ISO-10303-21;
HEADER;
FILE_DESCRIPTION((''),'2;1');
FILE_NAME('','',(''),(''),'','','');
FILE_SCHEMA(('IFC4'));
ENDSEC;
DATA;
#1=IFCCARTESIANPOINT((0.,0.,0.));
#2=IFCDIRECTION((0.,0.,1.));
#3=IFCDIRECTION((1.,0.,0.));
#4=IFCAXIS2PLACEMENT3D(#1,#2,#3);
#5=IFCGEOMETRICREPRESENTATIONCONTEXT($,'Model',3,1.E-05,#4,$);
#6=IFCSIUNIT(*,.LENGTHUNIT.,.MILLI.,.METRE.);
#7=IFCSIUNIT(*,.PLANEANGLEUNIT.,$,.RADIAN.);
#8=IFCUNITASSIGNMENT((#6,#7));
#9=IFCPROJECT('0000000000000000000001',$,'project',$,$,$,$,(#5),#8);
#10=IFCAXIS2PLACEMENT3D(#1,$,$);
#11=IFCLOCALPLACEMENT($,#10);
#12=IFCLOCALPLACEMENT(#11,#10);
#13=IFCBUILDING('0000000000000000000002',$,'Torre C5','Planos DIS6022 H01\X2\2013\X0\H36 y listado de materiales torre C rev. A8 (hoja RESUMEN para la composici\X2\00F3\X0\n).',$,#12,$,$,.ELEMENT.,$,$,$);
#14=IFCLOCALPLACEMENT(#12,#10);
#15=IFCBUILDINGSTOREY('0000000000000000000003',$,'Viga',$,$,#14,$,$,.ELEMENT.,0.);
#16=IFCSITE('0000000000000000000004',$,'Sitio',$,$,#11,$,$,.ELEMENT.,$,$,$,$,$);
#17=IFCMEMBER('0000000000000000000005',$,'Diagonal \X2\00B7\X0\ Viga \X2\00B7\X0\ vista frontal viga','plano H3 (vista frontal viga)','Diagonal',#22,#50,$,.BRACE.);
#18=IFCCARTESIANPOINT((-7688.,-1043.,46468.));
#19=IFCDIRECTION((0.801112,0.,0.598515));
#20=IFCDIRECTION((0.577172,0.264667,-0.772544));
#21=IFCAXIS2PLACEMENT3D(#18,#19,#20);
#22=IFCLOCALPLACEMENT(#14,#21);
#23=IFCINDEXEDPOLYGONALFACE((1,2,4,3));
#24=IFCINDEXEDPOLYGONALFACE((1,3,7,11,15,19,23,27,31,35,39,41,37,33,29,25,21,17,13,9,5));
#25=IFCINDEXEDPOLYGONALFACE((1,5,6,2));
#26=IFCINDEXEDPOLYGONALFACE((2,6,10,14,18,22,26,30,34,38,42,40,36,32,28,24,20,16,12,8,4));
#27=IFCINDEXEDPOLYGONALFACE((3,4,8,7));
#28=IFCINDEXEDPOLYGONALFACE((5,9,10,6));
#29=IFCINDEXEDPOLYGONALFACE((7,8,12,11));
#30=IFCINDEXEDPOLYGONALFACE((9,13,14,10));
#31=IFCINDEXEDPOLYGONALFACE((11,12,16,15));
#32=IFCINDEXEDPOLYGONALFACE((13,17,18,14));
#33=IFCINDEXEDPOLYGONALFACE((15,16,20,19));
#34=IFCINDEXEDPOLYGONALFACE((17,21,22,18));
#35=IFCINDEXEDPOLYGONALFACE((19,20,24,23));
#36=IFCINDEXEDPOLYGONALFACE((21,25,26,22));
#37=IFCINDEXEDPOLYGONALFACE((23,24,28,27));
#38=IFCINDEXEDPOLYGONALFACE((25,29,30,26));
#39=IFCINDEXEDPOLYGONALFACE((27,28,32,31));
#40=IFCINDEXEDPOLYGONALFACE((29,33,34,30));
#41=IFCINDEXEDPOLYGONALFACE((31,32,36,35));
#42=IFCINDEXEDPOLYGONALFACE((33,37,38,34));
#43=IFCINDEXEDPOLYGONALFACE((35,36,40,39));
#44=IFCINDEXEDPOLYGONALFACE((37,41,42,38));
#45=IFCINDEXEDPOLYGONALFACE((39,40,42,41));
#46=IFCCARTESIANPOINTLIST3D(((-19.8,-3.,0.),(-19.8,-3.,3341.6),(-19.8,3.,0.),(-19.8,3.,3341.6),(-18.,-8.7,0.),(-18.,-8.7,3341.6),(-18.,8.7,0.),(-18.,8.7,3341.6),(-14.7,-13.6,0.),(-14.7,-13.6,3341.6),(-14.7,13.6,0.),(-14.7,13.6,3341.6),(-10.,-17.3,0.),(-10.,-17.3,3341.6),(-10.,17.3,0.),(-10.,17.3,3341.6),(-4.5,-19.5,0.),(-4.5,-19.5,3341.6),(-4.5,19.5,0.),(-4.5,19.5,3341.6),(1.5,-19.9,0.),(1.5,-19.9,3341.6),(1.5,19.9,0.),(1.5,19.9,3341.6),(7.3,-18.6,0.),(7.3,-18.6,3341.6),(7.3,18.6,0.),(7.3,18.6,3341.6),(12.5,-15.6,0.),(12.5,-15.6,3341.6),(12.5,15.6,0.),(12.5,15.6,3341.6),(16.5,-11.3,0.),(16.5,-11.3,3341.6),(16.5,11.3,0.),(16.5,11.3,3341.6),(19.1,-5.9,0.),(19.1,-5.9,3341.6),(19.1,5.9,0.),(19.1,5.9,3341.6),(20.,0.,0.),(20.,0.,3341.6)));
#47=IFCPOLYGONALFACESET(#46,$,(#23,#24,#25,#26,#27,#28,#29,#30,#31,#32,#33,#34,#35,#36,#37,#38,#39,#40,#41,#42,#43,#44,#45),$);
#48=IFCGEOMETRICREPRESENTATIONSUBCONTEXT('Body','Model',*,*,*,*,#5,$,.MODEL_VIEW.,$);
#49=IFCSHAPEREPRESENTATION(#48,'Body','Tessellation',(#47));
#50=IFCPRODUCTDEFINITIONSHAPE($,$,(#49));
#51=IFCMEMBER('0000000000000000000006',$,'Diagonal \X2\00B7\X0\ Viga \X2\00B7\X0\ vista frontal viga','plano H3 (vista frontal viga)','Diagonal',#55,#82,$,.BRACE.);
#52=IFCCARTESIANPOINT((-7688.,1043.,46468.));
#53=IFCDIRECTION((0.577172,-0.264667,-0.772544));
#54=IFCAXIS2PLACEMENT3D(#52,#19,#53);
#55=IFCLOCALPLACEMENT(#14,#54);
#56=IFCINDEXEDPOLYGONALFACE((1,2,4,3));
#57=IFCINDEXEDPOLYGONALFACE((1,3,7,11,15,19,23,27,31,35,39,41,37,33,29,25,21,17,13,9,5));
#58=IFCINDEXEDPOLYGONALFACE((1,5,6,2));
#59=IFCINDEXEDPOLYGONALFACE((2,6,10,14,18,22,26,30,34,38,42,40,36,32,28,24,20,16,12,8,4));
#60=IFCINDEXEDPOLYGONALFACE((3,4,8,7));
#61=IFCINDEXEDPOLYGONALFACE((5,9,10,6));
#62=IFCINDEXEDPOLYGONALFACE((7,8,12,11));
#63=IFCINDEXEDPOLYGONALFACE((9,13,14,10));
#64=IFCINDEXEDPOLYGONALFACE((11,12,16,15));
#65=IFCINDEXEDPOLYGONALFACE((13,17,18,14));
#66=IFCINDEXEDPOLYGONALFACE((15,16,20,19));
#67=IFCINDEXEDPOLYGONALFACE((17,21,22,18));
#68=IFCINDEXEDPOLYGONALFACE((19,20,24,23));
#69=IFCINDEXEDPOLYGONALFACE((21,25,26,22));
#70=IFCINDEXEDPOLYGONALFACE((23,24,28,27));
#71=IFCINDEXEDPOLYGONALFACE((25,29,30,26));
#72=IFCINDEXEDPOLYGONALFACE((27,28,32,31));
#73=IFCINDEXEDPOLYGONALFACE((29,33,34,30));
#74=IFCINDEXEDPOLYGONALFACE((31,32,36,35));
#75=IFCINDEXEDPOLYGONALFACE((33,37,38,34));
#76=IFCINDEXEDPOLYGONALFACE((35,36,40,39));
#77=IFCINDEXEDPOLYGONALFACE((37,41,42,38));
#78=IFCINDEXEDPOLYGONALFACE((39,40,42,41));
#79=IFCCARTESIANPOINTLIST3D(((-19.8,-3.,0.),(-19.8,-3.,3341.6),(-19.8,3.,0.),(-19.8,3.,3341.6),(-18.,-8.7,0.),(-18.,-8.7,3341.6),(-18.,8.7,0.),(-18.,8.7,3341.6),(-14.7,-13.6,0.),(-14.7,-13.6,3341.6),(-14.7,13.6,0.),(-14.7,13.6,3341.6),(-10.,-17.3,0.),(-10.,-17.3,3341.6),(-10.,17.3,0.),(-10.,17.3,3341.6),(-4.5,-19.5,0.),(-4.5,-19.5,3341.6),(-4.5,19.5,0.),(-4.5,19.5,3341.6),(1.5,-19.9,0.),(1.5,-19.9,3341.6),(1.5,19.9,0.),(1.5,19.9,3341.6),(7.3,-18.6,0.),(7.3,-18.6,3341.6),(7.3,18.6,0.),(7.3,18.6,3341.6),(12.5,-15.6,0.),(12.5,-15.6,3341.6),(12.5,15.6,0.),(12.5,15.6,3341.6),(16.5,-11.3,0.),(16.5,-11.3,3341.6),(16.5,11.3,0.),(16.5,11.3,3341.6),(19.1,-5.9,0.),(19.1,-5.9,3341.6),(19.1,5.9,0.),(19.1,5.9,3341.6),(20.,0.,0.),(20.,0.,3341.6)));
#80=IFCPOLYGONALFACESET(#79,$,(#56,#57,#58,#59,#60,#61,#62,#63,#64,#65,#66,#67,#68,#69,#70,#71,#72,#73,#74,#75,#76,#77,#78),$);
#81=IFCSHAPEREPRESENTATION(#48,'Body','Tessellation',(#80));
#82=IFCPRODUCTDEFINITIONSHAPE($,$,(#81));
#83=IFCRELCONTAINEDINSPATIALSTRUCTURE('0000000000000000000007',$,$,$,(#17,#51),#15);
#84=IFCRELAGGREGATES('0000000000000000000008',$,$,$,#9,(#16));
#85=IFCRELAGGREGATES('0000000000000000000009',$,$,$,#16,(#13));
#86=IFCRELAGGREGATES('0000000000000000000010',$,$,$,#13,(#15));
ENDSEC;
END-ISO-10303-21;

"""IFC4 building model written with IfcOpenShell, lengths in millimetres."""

from ifc_helpers import new_model, si_unit, frame, origin, origin_with_axes, place, context, subcontext, project, spatial, circle, extrude, element, save


model = new_model("IFC4")

# Units and contexts
model_context = context("Model", 3, precision=1e-05, world=origin_with_axes())
body_context = subcontext(model_context, "Body", "Model", "MODEL_VIEW")
ifc_project = project(units=[si_unit("LENGTHUNIT", "METRE", prefix="MILLI"), si_unit("PLANEANGLEUNIT", "RADIAN")], contexts=[model_context])

# Site, building, storey
site_placement = place(None, origin())
site = spatial("IfcSite", under=ifc_project, at=site_placement, Name="Sitio", CompositionType="ELEMENT")
building_placement = place(site_placement, origin())
building = spatial("IfcBuilding", under=site, at=building_placement, Name="Torre C5", Description="Planos DIS6022 H01–H36 y listado de materiales torre C rev. A8 (hoja RESUMEN para la composición).", CompositionType="ELEMENT")
storey_placement = place(building_placement, origin())
storey = spatial("IfcBuildingStorey", under=building, at=storey_placement, Name="Viga", CompositionType="ELEMENT", Elevation=0.0)

# Members
for number, where, z_axis, x_axis, name in (
    (1, (-7688.0, -1043.0, 46468.0), (0.801112, 0.0, 0.598515), (0.577172, 0.264667, -0.772544), "Diagonal · Viga · vista frontal viga"),
    (2, (-7688.0, 1043.0, 46468.0), (0.801112, 0.0, 0.598515), (0.577172, -0.264667, -0.772544), "Diagonal · Viga · vista frontal viga"),
):
    element("IfcMember", number, at=place(storey_placement, frame(where, z_axis=z_axis, x_axis=x_axis)), inside=storey, Name=name, Description="plano H3 (vista frontal viga)", ObjectType="Diagonal", PredefinedType="BRACE", context=body_context, shape_type="SweptSolid", body=[
        extrude(circle(Radius=20.0), None, (0.0, 0.0, 1.0), 3341.6),
    ])

save(model, "model.ifc")
